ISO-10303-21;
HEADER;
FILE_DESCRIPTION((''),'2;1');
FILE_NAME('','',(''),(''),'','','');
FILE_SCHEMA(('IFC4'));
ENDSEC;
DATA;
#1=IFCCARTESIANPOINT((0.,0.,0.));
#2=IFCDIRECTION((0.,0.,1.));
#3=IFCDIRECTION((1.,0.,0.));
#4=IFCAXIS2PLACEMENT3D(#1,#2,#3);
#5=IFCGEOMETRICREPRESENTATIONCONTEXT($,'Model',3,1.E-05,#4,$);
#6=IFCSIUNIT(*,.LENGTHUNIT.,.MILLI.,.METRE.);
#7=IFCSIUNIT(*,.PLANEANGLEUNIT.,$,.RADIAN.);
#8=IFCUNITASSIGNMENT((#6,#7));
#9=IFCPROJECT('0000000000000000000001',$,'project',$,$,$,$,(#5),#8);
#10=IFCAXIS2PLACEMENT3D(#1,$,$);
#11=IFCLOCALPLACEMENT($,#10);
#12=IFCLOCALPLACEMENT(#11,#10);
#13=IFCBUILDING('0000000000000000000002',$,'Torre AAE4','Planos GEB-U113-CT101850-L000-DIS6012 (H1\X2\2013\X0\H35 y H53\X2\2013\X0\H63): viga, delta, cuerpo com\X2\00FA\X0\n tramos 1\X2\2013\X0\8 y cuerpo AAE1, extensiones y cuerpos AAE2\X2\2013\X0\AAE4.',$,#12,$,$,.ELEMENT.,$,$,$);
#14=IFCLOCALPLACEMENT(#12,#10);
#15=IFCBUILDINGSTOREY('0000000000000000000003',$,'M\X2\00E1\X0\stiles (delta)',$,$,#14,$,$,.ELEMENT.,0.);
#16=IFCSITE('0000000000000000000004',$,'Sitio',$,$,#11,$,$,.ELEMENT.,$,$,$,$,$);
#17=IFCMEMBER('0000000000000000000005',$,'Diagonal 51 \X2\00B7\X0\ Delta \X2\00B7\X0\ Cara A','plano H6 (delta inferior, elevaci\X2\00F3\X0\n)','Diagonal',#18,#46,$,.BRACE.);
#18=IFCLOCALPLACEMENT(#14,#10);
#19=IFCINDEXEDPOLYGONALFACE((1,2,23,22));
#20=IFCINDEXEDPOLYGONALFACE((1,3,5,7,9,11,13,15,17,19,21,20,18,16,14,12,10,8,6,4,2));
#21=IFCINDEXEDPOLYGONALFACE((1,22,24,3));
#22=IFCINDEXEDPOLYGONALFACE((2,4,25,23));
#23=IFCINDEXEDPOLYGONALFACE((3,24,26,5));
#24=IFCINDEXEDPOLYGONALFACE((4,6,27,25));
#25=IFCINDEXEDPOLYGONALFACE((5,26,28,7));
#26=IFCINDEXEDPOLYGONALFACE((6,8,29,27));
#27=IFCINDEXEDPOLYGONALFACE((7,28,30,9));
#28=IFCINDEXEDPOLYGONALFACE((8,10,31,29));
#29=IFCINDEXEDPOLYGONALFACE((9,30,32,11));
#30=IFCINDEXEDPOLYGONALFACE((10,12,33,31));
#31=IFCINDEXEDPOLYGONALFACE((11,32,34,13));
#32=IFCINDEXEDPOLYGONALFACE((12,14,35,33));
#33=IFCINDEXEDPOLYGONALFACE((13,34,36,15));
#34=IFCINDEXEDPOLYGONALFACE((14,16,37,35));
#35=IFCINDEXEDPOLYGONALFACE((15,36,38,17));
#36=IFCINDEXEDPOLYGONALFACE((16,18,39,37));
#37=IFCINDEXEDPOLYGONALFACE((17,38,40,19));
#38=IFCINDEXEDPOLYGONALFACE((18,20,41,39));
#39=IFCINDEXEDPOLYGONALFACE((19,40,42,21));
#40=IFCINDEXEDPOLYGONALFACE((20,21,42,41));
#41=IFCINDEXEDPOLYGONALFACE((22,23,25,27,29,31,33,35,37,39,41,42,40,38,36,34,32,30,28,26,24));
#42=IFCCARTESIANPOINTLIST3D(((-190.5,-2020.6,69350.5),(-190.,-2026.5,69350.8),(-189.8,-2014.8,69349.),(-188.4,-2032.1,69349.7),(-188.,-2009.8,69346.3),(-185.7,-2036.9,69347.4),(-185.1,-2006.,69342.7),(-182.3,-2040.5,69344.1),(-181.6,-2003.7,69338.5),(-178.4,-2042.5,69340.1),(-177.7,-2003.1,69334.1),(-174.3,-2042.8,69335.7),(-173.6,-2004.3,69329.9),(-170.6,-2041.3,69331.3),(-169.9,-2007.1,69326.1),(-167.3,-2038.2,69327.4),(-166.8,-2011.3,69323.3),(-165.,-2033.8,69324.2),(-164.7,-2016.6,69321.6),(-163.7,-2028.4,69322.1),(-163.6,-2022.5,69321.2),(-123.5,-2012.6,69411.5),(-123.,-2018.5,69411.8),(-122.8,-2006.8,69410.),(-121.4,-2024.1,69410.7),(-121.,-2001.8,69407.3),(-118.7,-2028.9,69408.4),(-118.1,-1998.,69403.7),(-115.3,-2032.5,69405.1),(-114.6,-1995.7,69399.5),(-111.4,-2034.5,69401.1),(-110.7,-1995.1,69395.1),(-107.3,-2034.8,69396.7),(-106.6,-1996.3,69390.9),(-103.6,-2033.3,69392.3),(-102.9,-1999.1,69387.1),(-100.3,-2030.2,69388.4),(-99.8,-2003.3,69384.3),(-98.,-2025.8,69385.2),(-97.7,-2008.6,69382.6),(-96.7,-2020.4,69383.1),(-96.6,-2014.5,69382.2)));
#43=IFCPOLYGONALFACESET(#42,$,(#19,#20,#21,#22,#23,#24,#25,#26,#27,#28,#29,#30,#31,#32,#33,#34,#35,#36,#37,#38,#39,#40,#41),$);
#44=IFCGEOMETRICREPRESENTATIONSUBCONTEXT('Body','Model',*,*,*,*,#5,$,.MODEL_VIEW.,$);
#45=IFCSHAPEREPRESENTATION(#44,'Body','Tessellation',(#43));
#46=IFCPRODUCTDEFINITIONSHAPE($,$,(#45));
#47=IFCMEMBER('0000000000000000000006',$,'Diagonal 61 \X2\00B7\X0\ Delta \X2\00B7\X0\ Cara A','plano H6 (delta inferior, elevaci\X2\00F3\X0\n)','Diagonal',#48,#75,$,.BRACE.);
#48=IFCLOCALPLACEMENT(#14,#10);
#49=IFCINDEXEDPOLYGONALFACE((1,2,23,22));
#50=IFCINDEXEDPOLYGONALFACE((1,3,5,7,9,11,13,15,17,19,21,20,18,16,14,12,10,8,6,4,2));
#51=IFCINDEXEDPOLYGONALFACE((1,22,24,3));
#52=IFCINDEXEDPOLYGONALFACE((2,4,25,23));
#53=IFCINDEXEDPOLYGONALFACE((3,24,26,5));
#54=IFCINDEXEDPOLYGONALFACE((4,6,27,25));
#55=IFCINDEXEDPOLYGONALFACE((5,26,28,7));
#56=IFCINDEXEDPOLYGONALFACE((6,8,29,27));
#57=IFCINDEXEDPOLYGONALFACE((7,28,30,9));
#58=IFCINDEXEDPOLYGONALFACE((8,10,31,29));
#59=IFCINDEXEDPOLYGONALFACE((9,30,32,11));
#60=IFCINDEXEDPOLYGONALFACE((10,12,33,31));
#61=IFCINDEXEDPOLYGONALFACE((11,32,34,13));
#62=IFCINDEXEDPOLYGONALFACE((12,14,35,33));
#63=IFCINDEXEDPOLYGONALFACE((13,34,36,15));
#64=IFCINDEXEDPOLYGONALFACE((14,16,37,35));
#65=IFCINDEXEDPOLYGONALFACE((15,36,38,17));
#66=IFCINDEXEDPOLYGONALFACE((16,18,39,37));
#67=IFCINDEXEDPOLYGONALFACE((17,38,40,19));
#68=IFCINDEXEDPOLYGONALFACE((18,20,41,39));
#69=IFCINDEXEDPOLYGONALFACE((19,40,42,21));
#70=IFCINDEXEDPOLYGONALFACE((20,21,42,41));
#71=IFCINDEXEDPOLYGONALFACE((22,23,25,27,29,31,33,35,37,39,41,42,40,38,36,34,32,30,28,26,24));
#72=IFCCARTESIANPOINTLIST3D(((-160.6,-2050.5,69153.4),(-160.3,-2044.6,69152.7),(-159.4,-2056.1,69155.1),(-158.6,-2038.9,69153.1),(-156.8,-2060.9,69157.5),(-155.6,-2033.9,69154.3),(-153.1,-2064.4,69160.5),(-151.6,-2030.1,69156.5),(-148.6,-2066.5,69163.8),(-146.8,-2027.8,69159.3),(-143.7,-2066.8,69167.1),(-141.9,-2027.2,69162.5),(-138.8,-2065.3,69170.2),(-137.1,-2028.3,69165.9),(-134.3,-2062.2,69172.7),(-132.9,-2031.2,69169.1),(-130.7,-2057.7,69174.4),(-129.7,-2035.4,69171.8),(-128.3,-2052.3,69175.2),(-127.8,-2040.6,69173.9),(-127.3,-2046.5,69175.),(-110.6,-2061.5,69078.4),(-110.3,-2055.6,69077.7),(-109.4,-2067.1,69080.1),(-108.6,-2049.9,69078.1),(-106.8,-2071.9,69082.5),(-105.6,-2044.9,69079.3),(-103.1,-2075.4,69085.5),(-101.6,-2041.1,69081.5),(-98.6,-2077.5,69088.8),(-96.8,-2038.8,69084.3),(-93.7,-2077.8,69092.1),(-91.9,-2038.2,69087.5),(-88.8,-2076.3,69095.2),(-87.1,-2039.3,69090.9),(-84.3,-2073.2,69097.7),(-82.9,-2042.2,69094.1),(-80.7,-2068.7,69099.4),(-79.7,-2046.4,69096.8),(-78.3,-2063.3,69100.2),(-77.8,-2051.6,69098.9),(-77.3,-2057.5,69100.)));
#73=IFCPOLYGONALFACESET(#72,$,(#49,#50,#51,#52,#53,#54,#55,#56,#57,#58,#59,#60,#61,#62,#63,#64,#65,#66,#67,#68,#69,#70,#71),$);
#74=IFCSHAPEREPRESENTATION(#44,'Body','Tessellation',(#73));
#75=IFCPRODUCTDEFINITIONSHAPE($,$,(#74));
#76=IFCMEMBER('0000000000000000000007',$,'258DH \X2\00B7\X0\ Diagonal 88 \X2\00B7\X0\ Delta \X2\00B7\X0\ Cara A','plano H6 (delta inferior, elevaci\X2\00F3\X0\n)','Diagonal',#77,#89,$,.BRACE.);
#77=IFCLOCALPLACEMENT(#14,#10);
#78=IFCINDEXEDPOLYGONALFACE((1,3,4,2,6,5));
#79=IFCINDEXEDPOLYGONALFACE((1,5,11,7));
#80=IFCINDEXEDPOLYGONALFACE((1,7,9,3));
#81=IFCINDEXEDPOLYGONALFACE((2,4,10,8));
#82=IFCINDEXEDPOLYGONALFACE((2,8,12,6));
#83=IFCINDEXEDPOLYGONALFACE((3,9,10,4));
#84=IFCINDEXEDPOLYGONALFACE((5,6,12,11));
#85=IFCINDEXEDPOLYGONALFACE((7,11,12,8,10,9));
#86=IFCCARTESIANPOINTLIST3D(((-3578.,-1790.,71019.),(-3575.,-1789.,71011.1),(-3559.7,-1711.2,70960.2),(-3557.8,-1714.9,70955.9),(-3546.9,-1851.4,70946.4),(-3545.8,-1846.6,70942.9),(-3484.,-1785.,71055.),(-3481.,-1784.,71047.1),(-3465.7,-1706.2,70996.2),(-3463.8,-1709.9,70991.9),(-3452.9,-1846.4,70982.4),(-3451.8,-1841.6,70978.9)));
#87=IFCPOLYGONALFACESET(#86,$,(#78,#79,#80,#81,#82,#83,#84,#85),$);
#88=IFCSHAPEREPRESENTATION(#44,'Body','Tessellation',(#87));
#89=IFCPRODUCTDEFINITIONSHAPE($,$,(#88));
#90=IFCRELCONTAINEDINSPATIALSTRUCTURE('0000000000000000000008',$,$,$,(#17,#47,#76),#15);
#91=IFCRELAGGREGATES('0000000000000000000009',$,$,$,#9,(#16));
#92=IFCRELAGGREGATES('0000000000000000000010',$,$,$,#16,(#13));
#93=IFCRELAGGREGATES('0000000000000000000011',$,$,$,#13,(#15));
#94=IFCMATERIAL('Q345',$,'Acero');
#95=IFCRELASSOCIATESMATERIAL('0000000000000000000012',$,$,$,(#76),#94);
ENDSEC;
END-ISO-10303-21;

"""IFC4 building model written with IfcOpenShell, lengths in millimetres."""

from ifc_helpers import new_model, si_unit, frame, frame_2d, origin, origin_with_axes, place, context, subcontext, project, spatial, circle, l_section, extrude, material, element, save


model = new_model("IFC4")

# Units and contexts
model_context = context("Model", 3, precision=1e-05, world=origin_with_axes())
body_context = subcontext(model_context, "Body", "Model", "MODEL_VIEW")
ifc_project = project(units=[si_unit("LENGTHUNIT", "METRE", prefix="MILLI"), si_unit("PLANEANGLEUNIT", "RADIAN")], contexts=[model_context])

# Site, building, storey
site_placement = place(None, origin())
site = spatial("IfcSite", under=ifc_project, at=site_placement, Name="Sitio", CompositionType="ELEMENT")
building_placement = place(site_placement, origin())
building = spatial("IfcBuilding", under=site, at=building_placement, Name="Torre AAE4", Description="Planos GEB-U113-CT101850-L000-DIS6012 (H1–H35 y H53–H63): viga, delta, cuerpo común tramos 1–8 y cuerpo AAE1, extensiones y cuerpos AAE2–AAE4.", CompositionType="ELEMENT")
storey_placement = place(building_placement, origin())
storey = spatial("IfcBuildingStorey", under=building, at=storey_placement, Name="Mástiles (delta)", CompositionType="ELEMENT", Elevation=0.0)

# Members
ifc_material_1 = material(Name="Q345", Category="Acero")
member_1_placement = place(storey_placement, frame((-177.0, -2023.0, 69336.0), z_axis=(0.736575, 0.087949, 0.670613), x_axis=(-0.032506, 0.994967, -0.094784)))
element("IfcMember", 1, at=member_1_placement, inside=storey, Name="Diagonal 51 · Delta · Cara A", Description="plano H6 (delta inferior, elevación)", ObjectType="Diagonal", PredefinedType="BRACE", context=body_context, shape_type="SweptSolid", body=[
    extrude(circle(Radius=20.0), None, (0.0, 0.0, 1.0), 91.0),
])
member_2_placement = place(storey_placement, frame((-144.0, -2047.0, 69164.0), z_axis=(0.550615, -0.121135, -0.825923), x_axis=(0.107346, 0.991475, -0.073852)))
element("IfcMember", 2, at=member_2_placement, inside=storey, Name="Diagonal 61 · Delta · Cara A", Description="plano H6 (delta inferior, elevación)", ObjectType="Diagonal", PredefinedType="BRACE", context=body_context, shape_type="SweptSolid", body=[
    extrude(circle(Radius=20.0), None, (0.0, 0.0, 1.0), 90.8),
])
member_3_placement = place(storey_placement, frame((-3484.0, -1785.0, 71055.0), z_axis=(-0.932707, -0.049612, -0.357207), x_axis=(0.183185, 0.788021, -0.587764)))
element("IfcMember", 3, at=member_3_placement, inside=storey, material=ifc_material_1, Name="258DH · Diagonal 88 · Delta · Cara A", Description="plano H6 (delta inferior, elevación)", ObjectType="Diagonal", PredefinedType="BRACE", context=body_context, shape_type="SweptSolid", body=[
    extrude(l_section(Depth=100.0, Width=100.0, Thickness=6.0, at=frame_2d((50.0, 50.0))), None, (0.0, 0.0, 1.0), 100.8),
])

save(model, "model.ifc")
